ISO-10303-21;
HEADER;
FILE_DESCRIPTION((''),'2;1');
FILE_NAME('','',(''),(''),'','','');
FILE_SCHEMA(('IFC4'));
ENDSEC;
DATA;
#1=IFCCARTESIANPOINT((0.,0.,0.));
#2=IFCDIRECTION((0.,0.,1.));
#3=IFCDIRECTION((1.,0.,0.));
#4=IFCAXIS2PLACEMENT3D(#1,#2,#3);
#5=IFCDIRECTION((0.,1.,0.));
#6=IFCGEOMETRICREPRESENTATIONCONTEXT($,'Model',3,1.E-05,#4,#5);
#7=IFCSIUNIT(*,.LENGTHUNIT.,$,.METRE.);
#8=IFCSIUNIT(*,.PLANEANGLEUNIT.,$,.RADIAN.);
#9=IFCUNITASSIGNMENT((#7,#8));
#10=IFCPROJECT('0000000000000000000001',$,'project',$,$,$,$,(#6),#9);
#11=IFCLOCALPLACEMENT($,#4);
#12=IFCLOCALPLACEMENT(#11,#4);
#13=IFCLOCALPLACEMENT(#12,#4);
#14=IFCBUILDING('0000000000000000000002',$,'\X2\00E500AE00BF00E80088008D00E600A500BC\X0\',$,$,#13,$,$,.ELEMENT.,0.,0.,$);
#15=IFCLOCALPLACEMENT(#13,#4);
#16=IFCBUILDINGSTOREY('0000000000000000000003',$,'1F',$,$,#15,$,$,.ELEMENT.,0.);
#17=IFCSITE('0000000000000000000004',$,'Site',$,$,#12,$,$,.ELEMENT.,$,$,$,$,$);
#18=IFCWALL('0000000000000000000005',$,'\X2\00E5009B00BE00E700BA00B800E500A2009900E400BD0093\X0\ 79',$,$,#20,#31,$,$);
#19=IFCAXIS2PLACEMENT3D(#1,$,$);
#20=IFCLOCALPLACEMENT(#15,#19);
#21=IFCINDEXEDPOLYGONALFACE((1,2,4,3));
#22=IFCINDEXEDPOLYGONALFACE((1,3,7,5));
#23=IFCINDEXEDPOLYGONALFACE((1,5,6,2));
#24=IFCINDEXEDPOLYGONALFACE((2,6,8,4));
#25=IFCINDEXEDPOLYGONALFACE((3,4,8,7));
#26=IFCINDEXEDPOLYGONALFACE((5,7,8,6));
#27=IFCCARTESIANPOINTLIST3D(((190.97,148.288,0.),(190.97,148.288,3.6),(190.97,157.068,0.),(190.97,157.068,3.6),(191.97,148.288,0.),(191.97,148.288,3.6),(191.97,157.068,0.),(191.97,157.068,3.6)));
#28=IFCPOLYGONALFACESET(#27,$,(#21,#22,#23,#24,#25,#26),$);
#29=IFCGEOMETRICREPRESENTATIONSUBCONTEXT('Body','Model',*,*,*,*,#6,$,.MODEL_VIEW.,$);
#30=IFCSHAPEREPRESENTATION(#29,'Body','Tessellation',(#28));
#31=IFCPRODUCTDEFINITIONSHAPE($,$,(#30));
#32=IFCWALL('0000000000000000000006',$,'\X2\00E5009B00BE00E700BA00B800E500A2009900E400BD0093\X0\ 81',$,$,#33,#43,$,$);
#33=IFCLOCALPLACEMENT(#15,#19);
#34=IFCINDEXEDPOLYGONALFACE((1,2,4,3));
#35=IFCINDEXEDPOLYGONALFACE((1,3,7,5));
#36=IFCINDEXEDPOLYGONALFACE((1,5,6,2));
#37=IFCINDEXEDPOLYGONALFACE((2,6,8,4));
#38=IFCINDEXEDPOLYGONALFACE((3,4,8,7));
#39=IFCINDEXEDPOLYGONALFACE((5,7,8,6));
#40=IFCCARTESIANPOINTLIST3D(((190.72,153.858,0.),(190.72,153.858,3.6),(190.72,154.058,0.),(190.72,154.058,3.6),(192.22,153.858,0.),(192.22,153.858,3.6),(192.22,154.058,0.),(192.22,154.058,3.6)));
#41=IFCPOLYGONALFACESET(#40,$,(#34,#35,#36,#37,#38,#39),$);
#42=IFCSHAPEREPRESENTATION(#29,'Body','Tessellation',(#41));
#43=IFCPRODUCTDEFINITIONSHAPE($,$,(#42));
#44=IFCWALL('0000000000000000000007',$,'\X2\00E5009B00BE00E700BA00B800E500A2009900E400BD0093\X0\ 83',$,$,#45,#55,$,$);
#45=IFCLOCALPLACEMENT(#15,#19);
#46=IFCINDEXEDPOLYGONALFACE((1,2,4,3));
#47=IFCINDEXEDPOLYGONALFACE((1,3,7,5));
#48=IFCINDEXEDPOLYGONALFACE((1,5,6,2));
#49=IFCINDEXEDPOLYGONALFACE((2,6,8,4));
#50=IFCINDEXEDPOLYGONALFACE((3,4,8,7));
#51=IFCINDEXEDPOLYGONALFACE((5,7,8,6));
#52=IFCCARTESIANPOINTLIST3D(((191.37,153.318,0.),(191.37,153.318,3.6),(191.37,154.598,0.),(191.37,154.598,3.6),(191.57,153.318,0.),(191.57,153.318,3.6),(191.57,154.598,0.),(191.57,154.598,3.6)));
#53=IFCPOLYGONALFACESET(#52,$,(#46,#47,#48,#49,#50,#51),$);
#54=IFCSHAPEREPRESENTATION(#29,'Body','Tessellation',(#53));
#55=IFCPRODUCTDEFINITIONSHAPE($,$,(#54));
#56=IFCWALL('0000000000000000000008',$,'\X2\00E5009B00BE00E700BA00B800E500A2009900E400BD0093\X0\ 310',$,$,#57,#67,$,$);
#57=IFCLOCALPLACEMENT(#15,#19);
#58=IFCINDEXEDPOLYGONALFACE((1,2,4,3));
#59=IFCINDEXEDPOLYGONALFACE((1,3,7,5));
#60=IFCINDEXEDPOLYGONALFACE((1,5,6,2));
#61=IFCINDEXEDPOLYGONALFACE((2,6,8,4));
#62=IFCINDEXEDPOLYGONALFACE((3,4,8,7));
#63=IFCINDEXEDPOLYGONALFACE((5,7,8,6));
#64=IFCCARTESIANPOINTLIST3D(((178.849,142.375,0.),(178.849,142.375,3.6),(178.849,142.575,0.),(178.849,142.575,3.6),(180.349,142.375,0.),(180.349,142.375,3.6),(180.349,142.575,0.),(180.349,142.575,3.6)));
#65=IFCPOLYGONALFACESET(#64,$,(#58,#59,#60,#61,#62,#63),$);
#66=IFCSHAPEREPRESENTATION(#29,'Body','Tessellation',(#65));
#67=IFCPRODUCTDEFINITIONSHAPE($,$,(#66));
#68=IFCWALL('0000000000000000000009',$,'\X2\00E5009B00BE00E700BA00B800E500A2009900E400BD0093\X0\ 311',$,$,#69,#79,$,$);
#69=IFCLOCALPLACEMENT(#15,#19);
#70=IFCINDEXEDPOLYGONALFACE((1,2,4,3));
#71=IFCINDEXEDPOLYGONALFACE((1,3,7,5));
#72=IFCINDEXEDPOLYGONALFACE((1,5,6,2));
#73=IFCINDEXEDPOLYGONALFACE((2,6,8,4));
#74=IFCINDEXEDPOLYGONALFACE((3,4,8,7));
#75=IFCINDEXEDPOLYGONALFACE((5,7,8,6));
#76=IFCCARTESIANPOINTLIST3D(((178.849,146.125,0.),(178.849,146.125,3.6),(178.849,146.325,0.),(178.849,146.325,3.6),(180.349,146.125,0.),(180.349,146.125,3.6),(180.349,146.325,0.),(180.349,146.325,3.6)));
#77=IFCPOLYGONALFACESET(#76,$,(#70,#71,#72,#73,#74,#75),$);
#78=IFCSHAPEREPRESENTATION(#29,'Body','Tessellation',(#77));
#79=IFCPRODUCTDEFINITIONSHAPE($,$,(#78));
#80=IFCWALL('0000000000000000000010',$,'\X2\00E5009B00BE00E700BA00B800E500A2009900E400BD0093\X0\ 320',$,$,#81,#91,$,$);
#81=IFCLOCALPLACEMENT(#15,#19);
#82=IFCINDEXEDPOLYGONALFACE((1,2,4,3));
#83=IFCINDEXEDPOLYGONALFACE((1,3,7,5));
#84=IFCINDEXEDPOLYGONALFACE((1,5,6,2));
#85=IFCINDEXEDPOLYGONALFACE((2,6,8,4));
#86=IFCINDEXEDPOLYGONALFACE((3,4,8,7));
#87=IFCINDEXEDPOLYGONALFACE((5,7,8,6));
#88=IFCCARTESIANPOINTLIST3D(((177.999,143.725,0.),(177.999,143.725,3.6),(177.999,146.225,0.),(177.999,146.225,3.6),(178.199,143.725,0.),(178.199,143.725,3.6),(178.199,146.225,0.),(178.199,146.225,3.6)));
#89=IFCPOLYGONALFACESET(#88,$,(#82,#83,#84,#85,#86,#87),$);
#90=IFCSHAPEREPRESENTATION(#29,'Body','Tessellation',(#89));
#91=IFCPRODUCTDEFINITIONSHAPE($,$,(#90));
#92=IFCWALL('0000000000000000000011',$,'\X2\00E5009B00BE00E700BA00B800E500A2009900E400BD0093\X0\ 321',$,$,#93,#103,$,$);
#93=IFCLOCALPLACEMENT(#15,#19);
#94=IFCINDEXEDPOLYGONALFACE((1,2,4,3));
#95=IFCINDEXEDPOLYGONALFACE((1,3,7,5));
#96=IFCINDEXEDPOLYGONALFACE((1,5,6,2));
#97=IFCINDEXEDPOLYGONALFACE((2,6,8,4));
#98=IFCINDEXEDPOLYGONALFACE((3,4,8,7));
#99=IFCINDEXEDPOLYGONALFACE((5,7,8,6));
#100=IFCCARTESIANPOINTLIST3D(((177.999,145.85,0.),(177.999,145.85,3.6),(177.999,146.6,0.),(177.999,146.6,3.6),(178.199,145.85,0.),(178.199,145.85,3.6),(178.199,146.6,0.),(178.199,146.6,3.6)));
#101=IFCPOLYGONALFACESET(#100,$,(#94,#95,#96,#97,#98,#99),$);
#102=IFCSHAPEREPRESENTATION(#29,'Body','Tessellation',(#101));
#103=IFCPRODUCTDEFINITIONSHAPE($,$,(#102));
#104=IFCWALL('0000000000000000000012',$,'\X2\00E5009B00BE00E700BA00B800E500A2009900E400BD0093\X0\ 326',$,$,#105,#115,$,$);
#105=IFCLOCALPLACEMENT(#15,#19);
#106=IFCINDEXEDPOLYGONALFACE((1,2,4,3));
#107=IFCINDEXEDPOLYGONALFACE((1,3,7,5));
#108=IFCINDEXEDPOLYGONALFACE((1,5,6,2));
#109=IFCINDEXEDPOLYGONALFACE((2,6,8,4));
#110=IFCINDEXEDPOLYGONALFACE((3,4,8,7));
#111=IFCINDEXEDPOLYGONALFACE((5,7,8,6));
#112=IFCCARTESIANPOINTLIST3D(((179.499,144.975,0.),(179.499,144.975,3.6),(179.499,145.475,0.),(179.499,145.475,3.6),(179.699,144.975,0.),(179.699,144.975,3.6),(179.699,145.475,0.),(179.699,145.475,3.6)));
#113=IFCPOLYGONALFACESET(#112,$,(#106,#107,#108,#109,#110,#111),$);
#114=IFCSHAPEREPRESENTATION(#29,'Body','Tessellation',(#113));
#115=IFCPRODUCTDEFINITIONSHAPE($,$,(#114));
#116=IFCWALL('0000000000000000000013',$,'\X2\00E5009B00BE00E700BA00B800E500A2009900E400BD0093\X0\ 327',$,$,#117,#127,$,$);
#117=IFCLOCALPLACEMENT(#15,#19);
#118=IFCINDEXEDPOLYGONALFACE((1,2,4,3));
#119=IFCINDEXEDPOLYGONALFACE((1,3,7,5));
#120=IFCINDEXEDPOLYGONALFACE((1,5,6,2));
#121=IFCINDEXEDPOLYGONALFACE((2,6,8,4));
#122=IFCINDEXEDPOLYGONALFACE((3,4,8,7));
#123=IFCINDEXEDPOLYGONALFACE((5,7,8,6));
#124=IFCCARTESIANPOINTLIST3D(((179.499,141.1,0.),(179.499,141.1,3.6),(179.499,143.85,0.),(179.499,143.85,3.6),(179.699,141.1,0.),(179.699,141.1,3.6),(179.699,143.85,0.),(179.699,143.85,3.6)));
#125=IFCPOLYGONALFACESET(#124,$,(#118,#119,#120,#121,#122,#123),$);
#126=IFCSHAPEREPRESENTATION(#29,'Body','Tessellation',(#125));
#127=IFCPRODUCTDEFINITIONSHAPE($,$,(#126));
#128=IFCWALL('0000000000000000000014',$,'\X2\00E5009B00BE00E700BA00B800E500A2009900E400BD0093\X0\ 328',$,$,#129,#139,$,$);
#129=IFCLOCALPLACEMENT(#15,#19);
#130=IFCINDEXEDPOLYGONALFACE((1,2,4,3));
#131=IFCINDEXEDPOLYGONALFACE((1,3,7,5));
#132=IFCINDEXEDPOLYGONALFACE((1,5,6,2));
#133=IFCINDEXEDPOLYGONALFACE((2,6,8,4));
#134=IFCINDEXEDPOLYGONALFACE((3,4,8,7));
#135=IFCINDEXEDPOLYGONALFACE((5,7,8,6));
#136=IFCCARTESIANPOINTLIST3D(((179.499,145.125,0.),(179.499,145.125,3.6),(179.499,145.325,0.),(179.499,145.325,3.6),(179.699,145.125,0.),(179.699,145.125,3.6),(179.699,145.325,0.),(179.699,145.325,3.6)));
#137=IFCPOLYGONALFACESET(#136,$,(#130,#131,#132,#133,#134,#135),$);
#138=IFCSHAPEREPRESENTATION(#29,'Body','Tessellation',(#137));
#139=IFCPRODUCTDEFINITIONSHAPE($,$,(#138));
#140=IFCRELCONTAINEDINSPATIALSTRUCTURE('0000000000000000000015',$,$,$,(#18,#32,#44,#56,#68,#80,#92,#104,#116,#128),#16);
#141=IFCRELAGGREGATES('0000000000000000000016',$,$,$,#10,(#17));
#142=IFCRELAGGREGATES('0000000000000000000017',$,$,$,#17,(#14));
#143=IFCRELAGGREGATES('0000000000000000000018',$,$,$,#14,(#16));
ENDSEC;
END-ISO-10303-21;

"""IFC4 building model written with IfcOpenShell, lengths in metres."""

from ifc_helpers import new_model, si_unit, direction, frame, frame_2d, origin_with_axes, place, context, subcontext, project, spatial, rectangle, extrude, element, save


model = new_model("IFC4")

# Units and contexts
model_context = context("Model", 3, precision=1e-05, world=origin_with_axes(), true_north=direction((0.0, 1.0, 0.0)))
body_context = subcontext(model_context, "Body", "Model", "MODEL_VIEW")
ifc_project = project(units=[si_unit("LENGTHUNIT", "METRE"), si_unit("PLANEANGLEUNIT", "RADIAN")], contexts=[model_context])

# Site, building, storey
placement = place(None, origin_with_axes())
site_placement = place(placement, origin_with_axes())
site = spatial("IfcSite", under=ifc_project, at=site_placement, Name="Site", CompositionType="ELEMENT")
building_placement = place(site_placement, origin_with_axes())
building = spatial("IfcBuilding", under=site, at=building_placement, Name="å®¿è\u0088\u008dæ¥¼", CompositionType="ELEMENT", ElevationOfRefHeight=0.0, ElevationOfTerrain=0.0)
storey_placement = place(building_placement, origin_with_axes())
storey = spatial("IfcBuildingStorey", under=building, at=storey_placement, Name="1F", CompositionType="ELEMENT", Elevation=0.0)

# Walls
wall_1_placement = place(storey_placement, frame((191.47, 152.678, 0.0), z_axis=(0.0, 0.0, 1.0), x_axis=(1.0, 0.0, 0.0)))
element("IfcWall", 1, at=wall_1_placement, inside=storey, Name="å\u009b¾çº¸å¢\u0099ä½\u0093 79", context=body_context, shape_type="SweptSolid", body=[
    extrude(rectangle(XDim=1.0, YDim=8.78, at=frame_2d((0.0, 0.0), x_axis=(1.0, 0.0, 0.0))), frame((0.0, 0.0, 0.0), z_axis=(0.0, 0.0, 1.0)), (0.0, 0.0, 1.0), 3.6),
])
wall_2_placement = place(storey_placement, frame((191.47, 153.958, 0.0), z_axis=(0.0, 0.0, 1.0), x_axis=(1.0, 0.0, 0.0)))
element("IfcWall", 2, at=wall_2_placement, inside=storey, Name="å\u009b¾çº¸å¢\u0099ä½\u0093 81", context=body_context, shape_type="SweptSolid", body=[
    extrude(rectangle(XDim=1.5, YDim=0.2, at=frame_2d((0.0, 0.0), x_axis=(1.0, 0.0, 0.0))), frame((0.0, 0.0, 0.0), z_axis=(0.0, 0.0, 1.0)), (0.0, 0.0, 1.0), 3.6),
])
wall_3_placement = place(storey_placement, frame((191.47, 153.958, 0.0), z_axis=(0.0, 0.0, 1.0), x_axis=(0.0, -1.0, 0.0)))
element("IfcWall", 3, at=wall_3_placement, inside=storey, Name="å\u009b¾çº¸å¢\u0099ä½\u0093 83", context=body_context, shape_type="SweptSolid", body=[
    extrude(rectangle(XDim=1.28, YDim=0.2, at=frame_2d((0.0, 0.0), x_axis=(1.0, 0.0, 0.0))), frame((0.0, 0.0, 0.0), z_axis=(0.0, 0.0, 1.0)), (0.0, 0.0, 1.0), 3.6),
])
for number, where, z_axis, x_axis, name in (
    (4, (179.599, 142.475, 0.0), (0.0, 0.0, 1.0), (-1.0, 0.0, 0.0), "å\u009b¾çº¸å¢\u0099ä½\u0093 310"),
    (5, (179.599, 146.225, 0.0), (0.0, 0.0, 1.0), (-1.0, 0.0, 0.0), "å\u009b¾çº¸å¢\u0099ä½\u0093 311"),
):
    element("IfcWall", number, at=place(storey_placement, frame(where, z_axis=z_axis, x_axis=x_axis)), inside=storey, Name=name, context=body_context, shape_type="SweptSolid", body=[
        extrude(rectangle(XDim=1.5, YDim=0.2, at=frame_2d((0.0, 0.0), x_axis=(1.0, 0.0, 0.0))), frame((0.0, 0.0, 0.0), z_axis=(0.0, 0.0, 1.0)), (0.0, 0.0, 1.0), 3.6),
    ])
wall_4_placement = place(storey_placement, frame((178.099, 144.975, 0.0), z_axis=(0.0, 0.0, 1.0), x_axis=(0.0, -1.0, 0.0)))
element("IfcWall", 6, at=wall_4_placement, inside=storey, Name="å\u009b¾çº¸å¢\u0099ä½\u0093 320", context=body_context, shape_type="SweptSolid", body=[
    extrude(rectangle(XDim=2.5, YDim=0.2, at=frame_2d((0.0, 0.0), x_axis=(1.0, 0.0, 0.0))), frame((0.0, 0.0, 0.0), z_axis=(0.0, 0.0, 1.0)), (0.0, 0.0, 1.0), 3.6),
])
wall_5_placement = place(storey_placement, frame((178.099, 146.225, 0.0), z_axis=(0.0, 0.0, 1.0), x_axis=(0.0, -1.0, 0.0)))
element("IfcWall", 7, at=wall_5_placement, inside=storey, Name="å\u009b¾çº¸å¢\u0099ä½\u0093 321", context=body_context, shape_type="SweptSolid", body=[
    extrude(rectangle(XDim=0.75, YDim=0.2, at=frame_2d((0.0, 0.0), x_axis=(1.0, 0.0, 0.0))), frame((0.0, 0.0, 0.0), z_axis=(0.0, 0.0, 1.0)), (0.0, 0.0, 1.0), 3.6),
])
wall_6_placement = place(storey_placement, frame((179.599, 145.225, 0.0), z_axis=(0.0, 0.0, 1.0), x_axis=(0.0, 1.0, 0.0)))
element("IfcWall", 8, at=wall_6_placement, inside=storey, Name="å\u009b¾çº¸å¢\u0099ä½\u0093 326", context=body_context, shape_type="SweptSolid", body=[
    extrude(rectangle(XDim=0.5, YDim=0.2, at=frame_2d((0.0, 0.0), x_axis=(1.0, 0.0, 0.0))), frame((0.0, 0.0, 0.0), z_axis=(0.0, 0.0, 1.0)), (0.0, 0.0, 1.0), 3.6),
])
wall_7_placement = place(storey_placement, frame((179.599, 142.475, 0.0), z_axis=(0.0, 0.0, 1.0), x_axis=(0.0, 1.0, 0.0)))
element("IfcWall", 9, at=wall_7_placement, inside=storey, Name="å\u009b¾çº¸å¢\u0099ä½\u0093 327", context=body_context, shape_type="SweptSolid", body=[
    extrude(rectangle(XDim=2.75, YDim=0.2, at=frame_2d((0.0, 0.0), x_axis=(1.0, 0.0, 0.0))), frame((0.0, 0.0, 0.0), z_axis=(0.0, 0.0, 1.0)), (0.0, 0.0, 1.0), 3.6),
])
wall_8_placement = place(storey_placement, frame((179.599, 145.225, 0.0), z_axis=(0.0, 0.0, 1.0), x_axis=(1.0, 0.0, 0.0)))
element("IfcWall", 10, at=wall_8_placement, inside=storey, Name="å\u009b¾çº¸å¢\u0099ä½\u0093 328", context=body_context, shape_type="SweptSolid", body=[
    extrude(rectangle(XDim=0.2, YDim=0.2, at=frame_2d((0.0, 0.0), x_axis=(1.0, 0.0, 0.0))), frame((0.0, 0.0, 0.0), z_axis=(0.0, 0.0, 1.0)), (0.0, 0.0, 1.0), 3.6),
])

save(model, "model.ifc")
